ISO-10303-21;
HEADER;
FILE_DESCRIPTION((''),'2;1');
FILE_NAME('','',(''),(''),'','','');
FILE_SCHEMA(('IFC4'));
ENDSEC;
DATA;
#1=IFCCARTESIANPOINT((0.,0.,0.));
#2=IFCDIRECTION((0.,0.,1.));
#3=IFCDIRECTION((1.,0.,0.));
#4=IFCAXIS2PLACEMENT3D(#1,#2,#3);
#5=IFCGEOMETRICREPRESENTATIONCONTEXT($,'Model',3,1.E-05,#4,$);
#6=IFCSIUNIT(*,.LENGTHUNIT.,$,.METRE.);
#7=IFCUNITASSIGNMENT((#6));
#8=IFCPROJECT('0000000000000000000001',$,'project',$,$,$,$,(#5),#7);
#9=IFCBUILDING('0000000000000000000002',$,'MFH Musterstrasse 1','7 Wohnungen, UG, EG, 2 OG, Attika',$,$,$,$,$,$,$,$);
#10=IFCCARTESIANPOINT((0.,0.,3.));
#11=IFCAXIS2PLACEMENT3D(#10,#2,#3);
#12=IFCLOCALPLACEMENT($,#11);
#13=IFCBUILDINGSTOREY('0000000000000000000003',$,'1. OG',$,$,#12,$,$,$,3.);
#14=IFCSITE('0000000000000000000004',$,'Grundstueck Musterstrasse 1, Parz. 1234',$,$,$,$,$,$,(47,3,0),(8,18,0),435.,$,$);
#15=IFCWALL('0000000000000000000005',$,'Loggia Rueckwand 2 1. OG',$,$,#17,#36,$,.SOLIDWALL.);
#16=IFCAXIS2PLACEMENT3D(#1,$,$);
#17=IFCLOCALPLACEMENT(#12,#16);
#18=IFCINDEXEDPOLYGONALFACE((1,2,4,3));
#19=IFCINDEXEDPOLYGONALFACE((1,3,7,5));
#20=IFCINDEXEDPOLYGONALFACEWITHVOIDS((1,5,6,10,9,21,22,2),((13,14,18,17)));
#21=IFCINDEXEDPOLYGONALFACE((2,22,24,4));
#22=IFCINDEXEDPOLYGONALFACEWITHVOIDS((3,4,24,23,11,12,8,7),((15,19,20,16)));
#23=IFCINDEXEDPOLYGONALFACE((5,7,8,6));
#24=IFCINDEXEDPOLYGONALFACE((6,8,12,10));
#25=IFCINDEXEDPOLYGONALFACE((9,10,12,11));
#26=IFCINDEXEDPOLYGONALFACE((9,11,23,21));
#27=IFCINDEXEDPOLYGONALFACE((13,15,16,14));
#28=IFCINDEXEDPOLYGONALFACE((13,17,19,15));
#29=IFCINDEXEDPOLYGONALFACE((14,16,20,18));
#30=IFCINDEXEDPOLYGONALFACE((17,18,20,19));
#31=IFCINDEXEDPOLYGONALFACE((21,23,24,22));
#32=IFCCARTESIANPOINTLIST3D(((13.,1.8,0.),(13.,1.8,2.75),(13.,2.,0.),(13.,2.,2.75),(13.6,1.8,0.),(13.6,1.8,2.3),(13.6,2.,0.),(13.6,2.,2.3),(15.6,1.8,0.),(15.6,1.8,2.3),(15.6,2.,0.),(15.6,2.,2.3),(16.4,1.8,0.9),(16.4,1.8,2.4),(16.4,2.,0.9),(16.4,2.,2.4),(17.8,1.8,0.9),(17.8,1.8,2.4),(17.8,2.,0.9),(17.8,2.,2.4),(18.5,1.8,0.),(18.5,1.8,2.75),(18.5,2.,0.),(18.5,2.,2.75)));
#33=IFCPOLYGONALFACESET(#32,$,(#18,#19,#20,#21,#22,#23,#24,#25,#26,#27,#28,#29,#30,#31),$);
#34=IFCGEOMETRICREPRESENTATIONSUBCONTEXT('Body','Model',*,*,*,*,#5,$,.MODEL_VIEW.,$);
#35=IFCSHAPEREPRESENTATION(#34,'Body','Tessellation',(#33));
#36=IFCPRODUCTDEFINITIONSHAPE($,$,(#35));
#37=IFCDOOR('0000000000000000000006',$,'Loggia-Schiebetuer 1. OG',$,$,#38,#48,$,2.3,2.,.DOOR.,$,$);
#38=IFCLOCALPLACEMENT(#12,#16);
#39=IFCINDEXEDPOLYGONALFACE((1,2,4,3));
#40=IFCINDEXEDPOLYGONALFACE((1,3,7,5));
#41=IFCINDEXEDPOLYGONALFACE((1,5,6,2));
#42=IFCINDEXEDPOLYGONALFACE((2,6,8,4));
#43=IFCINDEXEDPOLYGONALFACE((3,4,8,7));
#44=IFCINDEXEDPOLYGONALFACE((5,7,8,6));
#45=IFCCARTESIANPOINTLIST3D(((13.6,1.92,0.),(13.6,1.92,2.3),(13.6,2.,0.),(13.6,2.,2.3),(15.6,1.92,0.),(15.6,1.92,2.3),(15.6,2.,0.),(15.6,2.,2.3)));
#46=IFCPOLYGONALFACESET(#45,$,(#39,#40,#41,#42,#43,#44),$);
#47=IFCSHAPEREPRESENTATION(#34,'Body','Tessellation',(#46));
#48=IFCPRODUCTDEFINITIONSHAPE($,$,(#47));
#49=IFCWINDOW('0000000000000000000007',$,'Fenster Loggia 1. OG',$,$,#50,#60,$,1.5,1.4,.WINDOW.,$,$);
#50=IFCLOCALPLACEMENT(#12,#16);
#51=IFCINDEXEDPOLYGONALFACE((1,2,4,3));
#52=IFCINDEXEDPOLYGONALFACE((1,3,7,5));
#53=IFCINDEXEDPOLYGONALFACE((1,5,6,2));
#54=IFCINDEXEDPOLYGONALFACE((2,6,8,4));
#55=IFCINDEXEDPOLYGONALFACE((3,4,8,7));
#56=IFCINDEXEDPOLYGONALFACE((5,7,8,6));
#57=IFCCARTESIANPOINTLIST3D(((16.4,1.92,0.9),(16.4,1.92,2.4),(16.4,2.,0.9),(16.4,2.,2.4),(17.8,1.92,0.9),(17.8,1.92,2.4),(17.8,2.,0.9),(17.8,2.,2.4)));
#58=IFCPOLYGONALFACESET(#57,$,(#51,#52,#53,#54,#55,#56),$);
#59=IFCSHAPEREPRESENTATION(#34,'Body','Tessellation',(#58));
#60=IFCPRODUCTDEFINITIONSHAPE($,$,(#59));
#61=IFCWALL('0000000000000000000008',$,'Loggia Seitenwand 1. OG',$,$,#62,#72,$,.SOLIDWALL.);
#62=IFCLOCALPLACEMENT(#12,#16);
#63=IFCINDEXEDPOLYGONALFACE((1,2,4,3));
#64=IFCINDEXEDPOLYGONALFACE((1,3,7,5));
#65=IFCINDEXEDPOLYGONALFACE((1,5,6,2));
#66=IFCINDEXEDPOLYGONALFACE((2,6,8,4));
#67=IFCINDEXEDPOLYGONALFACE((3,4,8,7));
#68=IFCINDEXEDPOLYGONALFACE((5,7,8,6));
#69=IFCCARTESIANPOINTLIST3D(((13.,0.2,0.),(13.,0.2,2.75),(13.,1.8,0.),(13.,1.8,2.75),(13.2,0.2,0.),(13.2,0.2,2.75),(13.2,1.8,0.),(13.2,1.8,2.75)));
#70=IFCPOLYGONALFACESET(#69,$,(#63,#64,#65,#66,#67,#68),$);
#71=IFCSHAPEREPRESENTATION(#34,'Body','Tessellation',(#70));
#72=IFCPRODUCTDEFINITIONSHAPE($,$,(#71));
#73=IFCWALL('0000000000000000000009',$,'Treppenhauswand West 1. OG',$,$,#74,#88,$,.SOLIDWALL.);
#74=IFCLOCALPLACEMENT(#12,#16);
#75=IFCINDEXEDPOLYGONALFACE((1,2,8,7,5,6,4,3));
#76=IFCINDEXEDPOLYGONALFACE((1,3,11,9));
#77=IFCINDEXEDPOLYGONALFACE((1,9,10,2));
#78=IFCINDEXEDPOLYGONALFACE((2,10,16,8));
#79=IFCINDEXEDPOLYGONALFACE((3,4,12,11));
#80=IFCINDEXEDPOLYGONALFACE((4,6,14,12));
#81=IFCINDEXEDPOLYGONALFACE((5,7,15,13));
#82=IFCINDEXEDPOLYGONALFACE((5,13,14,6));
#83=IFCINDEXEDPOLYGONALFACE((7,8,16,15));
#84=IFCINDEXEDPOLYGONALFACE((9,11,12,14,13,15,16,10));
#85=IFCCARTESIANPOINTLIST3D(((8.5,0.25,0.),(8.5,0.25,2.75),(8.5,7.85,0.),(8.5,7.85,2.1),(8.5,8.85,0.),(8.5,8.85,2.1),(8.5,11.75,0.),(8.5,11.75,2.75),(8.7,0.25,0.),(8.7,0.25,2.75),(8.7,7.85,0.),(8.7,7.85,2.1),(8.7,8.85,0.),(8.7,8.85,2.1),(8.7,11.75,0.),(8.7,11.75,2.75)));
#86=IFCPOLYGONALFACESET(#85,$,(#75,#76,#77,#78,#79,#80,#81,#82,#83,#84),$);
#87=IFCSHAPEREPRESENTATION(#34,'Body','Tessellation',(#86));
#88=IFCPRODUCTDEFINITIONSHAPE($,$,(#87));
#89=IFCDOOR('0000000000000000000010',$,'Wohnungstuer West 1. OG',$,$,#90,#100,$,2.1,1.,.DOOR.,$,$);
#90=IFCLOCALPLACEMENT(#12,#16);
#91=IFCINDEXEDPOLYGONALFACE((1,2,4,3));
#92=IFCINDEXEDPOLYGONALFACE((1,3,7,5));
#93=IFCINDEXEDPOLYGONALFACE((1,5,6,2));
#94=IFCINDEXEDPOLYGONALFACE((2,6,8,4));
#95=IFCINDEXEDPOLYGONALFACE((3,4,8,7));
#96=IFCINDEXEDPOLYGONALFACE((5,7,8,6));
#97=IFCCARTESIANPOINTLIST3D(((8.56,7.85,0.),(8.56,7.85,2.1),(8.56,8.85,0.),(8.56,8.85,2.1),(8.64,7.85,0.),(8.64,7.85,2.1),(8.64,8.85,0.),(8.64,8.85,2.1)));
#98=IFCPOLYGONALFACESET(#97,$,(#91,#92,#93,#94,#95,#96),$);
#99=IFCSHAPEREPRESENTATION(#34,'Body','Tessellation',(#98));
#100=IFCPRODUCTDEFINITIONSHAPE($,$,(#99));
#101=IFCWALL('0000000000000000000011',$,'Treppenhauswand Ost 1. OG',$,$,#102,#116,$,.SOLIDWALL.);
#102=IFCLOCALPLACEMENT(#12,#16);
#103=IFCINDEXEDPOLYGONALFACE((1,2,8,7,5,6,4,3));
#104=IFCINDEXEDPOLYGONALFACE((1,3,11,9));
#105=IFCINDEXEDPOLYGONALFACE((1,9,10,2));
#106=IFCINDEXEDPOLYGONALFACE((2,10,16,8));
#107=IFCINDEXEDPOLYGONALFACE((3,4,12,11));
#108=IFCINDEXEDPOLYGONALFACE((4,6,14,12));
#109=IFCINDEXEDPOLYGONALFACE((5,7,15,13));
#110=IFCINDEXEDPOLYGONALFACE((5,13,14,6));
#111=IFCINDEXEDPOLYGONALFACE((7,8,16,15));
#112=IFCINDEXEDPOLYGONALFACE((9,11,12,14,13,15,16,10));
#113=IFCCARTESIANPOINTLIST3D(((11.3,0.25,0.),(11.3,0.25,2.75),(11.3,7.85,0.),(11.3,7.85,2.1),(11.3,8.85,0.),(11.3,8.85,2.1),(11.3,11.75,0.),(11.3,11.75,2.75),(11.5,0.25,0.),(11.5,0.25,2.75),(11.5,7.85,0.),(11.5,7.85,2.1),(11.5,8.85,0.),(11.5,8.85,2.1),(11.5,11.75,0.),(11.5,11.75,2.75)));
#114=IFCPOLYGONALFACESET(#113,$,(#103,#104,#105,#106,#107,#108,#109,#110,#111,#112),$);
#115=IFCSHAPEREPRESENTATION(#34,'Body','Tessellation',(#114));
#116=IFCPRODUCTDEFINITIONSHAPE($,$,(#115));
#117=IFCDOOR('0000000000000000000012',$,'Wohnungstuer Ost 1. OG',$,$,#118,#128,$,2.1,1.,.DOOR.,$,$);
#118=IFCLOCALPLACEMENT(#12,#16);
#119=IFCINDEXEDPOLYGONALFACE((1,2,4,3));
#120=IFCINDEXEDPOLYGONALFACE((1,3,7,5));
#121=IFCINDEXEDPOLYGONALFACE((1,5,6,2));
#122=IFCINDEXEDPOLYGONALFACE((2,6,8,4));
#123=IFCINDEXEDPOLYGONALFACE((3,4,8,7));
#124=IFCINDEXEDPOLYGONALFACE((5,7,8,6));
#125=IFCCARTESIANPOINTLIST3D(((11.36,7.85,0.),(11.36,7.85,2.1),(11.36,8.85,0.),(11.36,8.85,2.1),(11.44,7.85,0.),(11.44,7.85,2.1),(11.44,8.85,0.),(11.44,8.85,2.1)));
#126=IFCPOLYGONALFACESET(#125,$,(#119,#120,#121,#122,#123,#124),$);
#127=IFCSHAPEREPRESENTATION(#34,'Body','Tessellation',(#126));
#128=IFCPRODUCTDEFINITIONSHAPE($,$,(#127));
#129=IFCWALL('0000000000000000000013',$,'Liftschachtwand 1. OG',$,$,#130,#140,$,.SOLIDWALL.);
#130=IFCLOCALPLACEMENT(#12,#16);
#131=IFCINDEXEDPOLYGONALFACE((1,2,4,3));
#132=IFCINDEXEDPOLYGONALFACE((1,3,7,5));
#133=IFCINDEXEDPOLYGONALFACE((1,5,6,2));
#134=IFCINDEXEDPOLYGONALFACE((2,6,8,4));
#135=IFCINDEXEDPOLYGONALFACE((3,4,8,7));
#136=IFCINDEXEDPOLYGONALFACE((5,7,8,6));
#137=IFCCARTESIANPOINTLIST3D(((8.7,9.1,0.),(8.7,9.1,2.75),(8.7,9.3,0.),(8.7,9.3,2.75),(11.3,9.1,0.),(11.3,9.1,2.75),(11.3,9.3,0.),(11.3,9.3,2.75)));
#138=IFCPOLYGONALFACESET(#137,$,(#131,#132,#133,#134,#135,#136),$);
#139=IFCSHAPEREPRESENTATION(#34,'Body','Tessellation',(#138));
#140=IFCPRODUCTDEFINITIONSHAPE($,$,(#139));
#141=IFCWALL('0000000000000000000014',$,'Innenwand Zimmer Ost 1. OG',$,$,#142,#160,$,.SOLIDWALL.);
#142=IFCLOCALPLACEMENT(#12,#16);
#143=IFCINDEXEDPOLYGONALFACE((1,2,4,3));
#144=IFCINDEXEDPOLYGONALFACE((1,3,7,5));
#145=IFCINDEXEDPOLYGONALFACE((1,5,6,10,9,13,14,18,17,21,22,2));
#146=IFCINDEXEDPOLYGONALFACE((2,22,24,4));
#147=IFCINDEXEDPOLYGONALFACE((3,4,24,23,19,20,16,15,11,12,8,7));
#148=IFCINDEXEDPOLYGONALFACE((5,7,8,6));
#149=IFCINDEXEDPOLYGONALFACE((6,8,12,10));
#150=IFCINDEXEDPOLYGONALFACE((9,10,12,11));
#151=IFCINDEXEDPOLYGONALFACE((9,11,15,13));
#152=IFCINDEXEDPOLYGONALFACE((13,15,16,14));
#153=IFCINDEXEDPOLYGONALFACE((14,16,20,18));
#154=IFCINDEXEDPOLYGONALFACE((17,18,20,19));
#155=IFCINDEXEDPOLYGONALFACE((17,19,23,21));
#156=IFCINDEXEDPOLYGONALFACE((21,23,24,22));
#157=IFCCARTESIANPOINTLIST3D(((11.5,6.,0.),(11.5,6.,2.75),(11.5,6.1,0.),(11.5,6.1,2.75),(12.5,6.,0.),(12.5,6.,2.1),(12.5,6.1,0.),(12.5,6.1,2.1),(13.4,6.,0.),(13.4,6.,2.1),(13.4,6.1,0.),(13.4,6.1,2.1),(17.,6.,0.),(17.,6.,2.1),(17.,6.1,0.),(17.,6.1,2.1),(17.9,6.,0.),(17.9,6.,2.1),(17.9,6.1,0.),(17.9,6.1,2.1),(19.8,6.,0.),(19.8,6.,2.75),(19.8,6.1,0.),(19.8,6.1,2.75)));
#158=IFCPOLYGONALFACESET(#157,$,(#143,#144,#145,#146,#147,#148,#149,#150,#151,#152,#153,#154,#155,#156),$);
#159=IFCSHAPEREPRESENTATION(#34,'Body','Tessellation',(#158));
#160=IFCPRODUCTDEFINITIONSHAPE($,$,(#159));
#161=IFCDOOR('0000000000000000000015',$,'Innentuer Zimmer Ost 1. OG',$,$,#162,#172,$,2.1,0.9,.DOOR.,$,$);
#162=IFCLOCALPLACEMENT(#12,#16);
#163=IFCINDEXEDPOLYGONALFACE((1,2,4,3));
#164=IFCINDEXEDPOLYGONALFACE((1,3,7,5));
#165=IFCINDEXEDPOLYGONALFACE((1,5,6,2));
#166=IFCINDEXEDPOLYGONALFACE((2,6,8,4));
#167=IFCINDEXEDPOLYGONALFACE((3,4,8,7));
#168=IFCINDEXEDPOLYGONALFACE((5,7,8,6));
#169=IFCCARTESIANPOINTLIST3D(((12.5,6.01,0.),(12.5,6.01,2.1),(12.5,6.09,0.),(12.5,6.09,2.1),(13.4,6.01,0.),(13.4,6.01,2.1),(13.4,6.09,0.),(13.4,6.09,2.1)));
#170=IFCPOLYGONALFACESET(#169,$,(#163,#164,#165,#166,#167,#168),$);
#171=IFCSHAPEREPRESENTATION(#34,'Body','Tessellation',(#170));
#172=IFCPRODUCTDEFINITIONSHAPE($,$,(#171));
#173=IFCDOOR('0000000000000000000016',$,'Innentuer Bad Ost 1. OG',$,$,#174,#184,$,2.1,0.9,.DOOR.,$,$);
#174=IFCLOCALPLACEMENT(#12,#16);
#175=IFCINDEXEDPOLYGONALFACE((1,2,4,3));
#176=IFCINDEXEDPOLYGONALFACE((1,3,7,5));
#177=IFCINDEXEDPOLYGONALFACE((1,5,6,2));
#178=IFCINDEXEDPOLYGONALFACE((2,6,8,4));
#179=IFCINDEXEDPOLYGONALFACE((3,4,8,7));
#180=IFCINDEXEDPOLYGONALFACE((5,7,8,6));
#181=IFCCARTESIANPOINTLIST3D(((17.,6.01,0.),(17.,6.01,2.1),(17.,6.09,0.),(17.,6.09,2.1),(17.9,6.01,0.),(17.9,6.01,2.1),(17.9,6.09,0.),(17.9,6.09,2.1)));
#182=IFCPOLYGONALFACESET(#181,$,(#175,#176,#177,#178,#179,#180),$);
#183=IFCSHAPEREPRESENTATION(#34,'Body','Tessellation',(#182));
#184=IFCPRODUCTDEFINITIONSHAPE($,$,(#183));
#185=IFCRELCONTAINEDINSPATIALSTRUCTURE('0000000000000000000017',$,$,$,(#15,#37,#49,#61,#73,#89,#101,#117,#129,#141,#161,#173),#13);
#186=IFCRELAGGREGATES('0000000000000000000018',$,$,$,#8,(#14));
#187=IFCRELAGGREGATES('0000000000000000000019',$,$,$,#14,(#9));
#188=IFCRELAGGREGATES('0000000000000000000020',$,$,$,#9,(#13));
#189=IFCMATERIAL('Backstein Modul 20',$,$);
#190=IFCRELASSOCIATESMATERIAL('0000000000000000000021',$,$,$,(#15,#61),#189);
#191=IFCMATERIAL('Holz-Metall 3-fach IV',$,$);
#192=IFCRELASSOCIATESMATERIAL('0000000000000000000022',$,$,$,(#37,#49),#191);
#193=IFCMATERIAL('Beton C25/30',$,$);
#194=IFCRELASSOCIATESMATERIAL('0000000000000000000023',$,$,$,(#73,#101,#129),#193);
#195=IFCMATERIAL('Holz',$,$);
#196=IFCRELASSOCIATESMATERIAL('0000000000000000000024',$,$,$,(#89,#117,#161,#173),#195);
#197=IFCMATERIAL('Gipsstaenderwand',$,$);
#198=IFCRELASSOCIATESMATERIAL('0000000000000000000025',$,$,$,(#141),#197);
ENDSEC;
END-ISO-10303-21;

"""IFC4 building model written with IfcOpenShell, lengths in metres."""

from ifc_helpers import new_model, si_unit, frame, frame_2d, origin_with_axes, place, context, subcontext, project, spatial, rectangle, extrude, material, element, fill, save


model = new_model("IFC4")

# Units and contexts
model_context = context("Model", 3, precision=1e-05, world=origin_with_axes())
body_context = subcontext(model_context, "Body", "Model", "MODEL_VIEW")
ifc_project = project(units=[si_unit("LENGTHUNIT", "METRE")], contexts=[model_context])

# Site, building, storey
site = spatial("IfcSite", under=ifc_project, Name="Grundstueck Musterstrasse 1, Parz. 1234", RefLatitude=(47, 3, 0), RefLongitude=(8, 18, 0), RefElevation=435.0)
building = spatial("IfcBuilding", under=site, Name="MFH Musterstrasse 1", Description="7 Wohnungen, UG, EG, 2 OG, Attika")
storey_placement = place(None, frame((0.0, 0.0, 3.0), z_axis=(0.0, 0.0, 1.0), x_axis=(1.0, 0.0, 0.0)))
storey = spatial("IfcBuildingStorey", under=building, at=storey_placement, Name="1. OG", Elevation=3.0)

# Wall, openings, door, window
ifc_material_1 = material(Name="Backstein Modul 20")
wall_1_placement = place(storey_placement, frame((13.0, 1.8, 0.0), z_axis=(0.0, 0.0, 1.0), x_axis=(1.0, 0.0, 0.0)))
wall_1 = element("IfcWall", 1, at=wall_1_placement, inside=storey, material=ifc_material_1, Name="Loggia Rueckwand 2 1. OG", PredefinedType="SOLIDWALL", context=body_context, shape_type="SweptSolid", body=[
    extrude(rectangle(XDim=5.5, YDim=0.2, at=frame_2d((2.75, 0.1))), origin_with_axes(), (0.0, 0.0, 1.0), 2.75),
])
opening_1_placement = place(wall_1_placement, frame((0.6, -0.21, 0.0), z_axis=(0.0, 0.0, 1.0), x_axis=(1.0, 0.0, 0.0)))
opening_1 = element("IfcOpeningElement", 2, at=opening_1_placement, cuts=wall_1, context=body_context, shape_type="SweptSolid", body=[
    extrude(rectangle(XDim=2.0, YDim=0.42, at=frame_2d((1.0, 0.21))), origin_with_axes(), (0.0, 0.0, 1.0), 2.3),
])
opening_2_placement = place(wall_1_placement, frame((3.4, -0.21, 0.9), z_axis=(0.0, 0.0, 1.0), x_axis=(1.0, 0.0, 0.0)))
opening_2 = element("IfcOpeningElement", 3, at=opening_2_placement, cuts=wall_1, context=body_context, shape_type="SweptSolid", body=[
    extrude(rectangle(XDim=1.4, YDim=0.42, at=frame_2d((0.7, 0.21))), origin_with_axes(), (0.0, 0.0, 1.0), 1.5),
])
ifc_material_2 = material(Name="Holz-Metall 3-fach IV")
door_1_placement = place(storey_placement, frame((13.6, 1.92, 0.0), z_axis=(0.0, 0.0, 1.0), x_axis=(1.0, 0.0, 0.0)))
door_1 = element("IfcDoor", 4, at=door_1_placement, inside=storey, material=ifc_material_2, Name="Loggia-Schiebetuer 1. OG", OverallHeight=2.3, OverallWidth=2.0, PredefinedType="DOOR", context=body_context, shape_type="SweptSolid", body=[
    extrude(rectangle(XDim=2.0, YDim=0.08, at=frame_2d((1.0, 0.04))), origin_with_axes(), (0.0, 0.0, 1.0), 2.3),
])
fill(opening_1, door_1)
window_placement = place(storey_placement, frame((16.4, 1.92, 0.9), z_axis=(0.0, 0.0, 1.0), x_axis=(1.0, 0.0, 0.0)))
window = element("IfcWindow", 5, at=window_placement, inside=storey, material=ifc_material_2, Name="Fenster Loggia 1. OG", OverallHeight=1.5, OverallWidth=1.4, PredefinedType="WINDOW", context=body_context, shape_type="SweptSolid", body=[
    extrude(rectangle(XDim=1.4, YDim=0.08, at=frame_2d((0.7, 0.04))), origin_with_axes(), (0.0, 0.0, 1.0), 1.5),
])
fill(opening_2, window)

# Wall
wall_2_placement = place(storey_placement, frame((13.0, 0.2, 0.0), z_axis=(0.0, 0.0, 1.0), x_axis=(1.0, 0.0, 0.0)))
element("IfcWall", 6, at=wall_2_placement, inside=storey, material=ifc_material_1, Name="Loggia Seitenwand 1. OG", PredefinedType="SOLIDWALL", context=body_context, shape_type="SweptSolid", body=[
    extrude(rectangle(XDim=0.2, YDim=1.6, at=frame_2d((0.1, 0.8))), origin_with_axes(), (0.0, 0.0, 1.0), 2.75),
])

# Walls, openings, doors
ifc_material_3 = material(Name="Beton C25/30")
wall_3_placement = place(storey_placement, frame((8.5, 0.25, 0.0), z_axis=(0.0, 0.0, 1.0), x_axis=(1.0, 0.0, 0.0)))
wall_3 = element("IfcWall", 7, at=wall_3_placement, inside=storey, material=ifc_material_3, Name="Treppenhauswand West 1. OG", PredefinedType="SOLIDWALL", context=body_context, shape_type="SweptSolid", body=[
    extrude(rectangle(XDim=0.2, YDim=11.5, at=frame_2d((0.1, 5.75))), origin_with_axes(), (0.0, 0.0, 1.0), 2.75),
])
opening_3_placement = place(wall_3_placement, frame((-0.01, 7.6, 0.0), z_axis=(0.0, 0.0, 1.0), x_axis=(1.0, 0.0, 0.0)))
opening_3 = element("IfcOpeningElement", 8, at=opening_3_placement, cuts=wall_3, context=body_context, shape_type="SweptSolid", body=[
    extrude(rectangle(XDim=0.22, YDim=1.0, at=frame_2d((0.11, 0.5))), origin_with_axes(), (0.0, 0.0, 1.0), 2.1),
])
ifc_material_4 = material(Name="Holz")
door_2_placement = place(storey_placement, frame((8.56, 7.85, 0.0), z_axis=(0.0, 0.0, 1.0), x_axis=(1.0, 0.0, 0.0)))
door_2 = element("IfcDoor", 9, at=door_2_placement, inside=storey, material=ifc_material_4, Name="Wohnungstuer West 1. OG", OverallHeight=2.1, OverallWidth=1.0, PredefinedType="DOOR", context=body_context, shape_type="SweptSolid", body=[
    extrude(rectangle(XDim=0.08, YDim=1.0, at=frame_2d((0.04, 0.5))), origin_with_axes(), (0.0, 0.0, 1.0), 2.1),
])
fill(opening_3, door_2)
wall_4_placement = place(storey_placement, frame((11.3, 0.25, 0.0), z_axis=(0.0, 0.0, 1.0), x_axis=(1.0, 0.0, 0.0)))
wall_4 = element("IfcWall", 10, at=wall_4_placement, inside=storey, material=ifc_material_3, Name="Treppenhauswand Ost 1. OG", PredefinedType="SOLIDWALL", context=body_context, shape_type="SweptSolid", body=[
    extrude(rectangle(XDim=0.2, YDim=11.5, at=frame_2d((0.1, 5.75))), origin_with_axes(), (0.0, 0.0, 1.0), 2.75),
])
opening_4_placement = place(wall_4_placement, frame((-0.01, 7.6, 0.0), z_axis=(0.0, 0.0, 1.0), x_axis=(1.0, 0.0, 0.0)))
opening_4 = element("IfcOpeningElement", 11, at=opening_4_placement, cuts=wall_4, context=body_context, shape_type="SweptSolid", body=[
    extrude(rectangle(XDim=0.22, YDim=1.0, at=frame_2d((0.11, 0.5))), origin_with_axes(), (0.0, 0.0, 1.0), 2.1),
])
door_3_placement = place(storey_placement, frame((11.36, 7.85, 0.0), z_axis=(0.0, 0.0, 1.0), x_axis=(1.0, 0.0, 0.0)))
door_3 = element("IfcDoor", 12, at=door_3_placement, inside=storey, material=ifc_material_4, Name="Wohnungstuer Ost 1. OG", OverallHeight=2.1, OverallWidth=1.0, PredefinedType="DOOR", context=body_context, shape_type="SweptSolid", body=[
    extrude(rectangle(XDim=0.08, YDim=1.0, at=frame_2d((0.04, 0.5))), origin_with_axes(), (0.0, 0.0, 1.0), 2.1),
])
fill(opening_4, door_3)

# Wall
wall_5_placement = place(storey_placement, frame((8.7, 9.1, 0.0), z_axis=(0.0, 0.0, 1.0), x_axis=(1.0, 0.0, 0.0)))
element("IfcWall", 13, at=wall_5_placement, inside=storey, material=ifc_material_3, Name="Liftschachtwand 1. OG", PredefinedType="SOLIDWALL", context=body_context, shape_type="SweptSolid", body=[
    extrude(rectangle(XDim=2.6, YDim=0.2, at=frame_2d((1.3, 0.1))), origin_with_axes(), (0.0, 0.0, 1.0), 2.75),
])

# Wall, openings, doors
ifc_material_5 = material(Name="Gipsstaenderwand")
wall_6_placement = place(storey_placement, frame((11.5, 6.0, 0.0), z_axis=(0.0, 0.0, 1.0), x_axis=(1.0, 0.0, 0.0)))
wall_6 = element("IfcWall", 14, at=wall_6_placement, inside=storey, material=ifc_material_5, Name="Innenwand Zimmer Ost 1. OG", PredefinedType="SOLIDWALL", context=body_context, shape_type="SweptSolid", body=[
    extrude(rectangle(XDim=8.3, YDim=0.1, at=frame_2d((4.15, 0.05))), origin_with_axes(), (0.0, 0.0, 1.0), 2.75),
])
opening_5_placement = place(wall_6_placement, frame((1.0, -0.01, 0.0), z_axis=(0.0, 0.0, 1.0), x_axis=(1.0, 0.0, 0.0)))
opening_5 = element("IfcOpeningElement", 15, at=opening_5_placement, cuts=wall_6, context=body_context, shape_type="SweptSolid", body=[
    extrude(rectangle(XDim=0.9, YDim=0.12, at=frame_2d((0.45, 0.06))), origin_with_axes(), (0.0, 0.0, 1.0), 2.1),
])
opening_6_placement = place(wall_6_placement, frame((5.5, -0.01, 0.0), z_axis=(0.0, 0.0, 1.0), x_axis=(1.0, 0.0, 0.0)))
opening_6 = element("IfcOpeningElement", 16, at=opening_6_placement, cuts=wall_6, context=body_context, shape_type="SweptSolid", body=[
    extrude(rectangle(XDim=0.9, YDim=0.12, at=frame_2d((0.45, 0.06))), origin_with_axes(), (0.0, 0.0, 1.0), 2.1),
])
door_4_placement = place(storey_placement, frame((12.5, 6.01, 0.0), z_axis=(0.0, 0.0, 1.0), x_axis=(1.0, 0.0, 0.0)))
door_4 = element("IfcDoor", 17, at=door_4_placement, inside=storey, material=ifc_material_4, Name="Innentuer Zimmer Ost 1. OG", OverallHeight=2.1, OverallWidth=0.9, PredefinedType="DOOR", context=body_context, shape_type="SweptSolid", body=[
    extrude(rectangle(XDim=0.9, YDim=0.08, at=frame_2d((0.45, 0.04))), origin_with_axes(), (0.0, 0.0, 1.0), 2.1),
])
fill(opening_5, door_4)
door_5_placement = place(storey_placement, frame((17.0, 6.01, 0.0), z_axis=(0.0, 0.0, 1.0), x_axis=(1.0, 0.0, 0.0)))
door_5 = element("IfcDoor", 18, at=door_5_placement, inside=storey, material=ifc_material_4, Name="Innentuer Bad Ost 1. OG", OverallHeight=2.1, OverallWidth=0.9, PredefinedType="DOOR", context=body_context, shape_type="SweptSolid", body=[
    extrude(rectangle(XDim=0.9, YDim=0.08, at=frame_2d((0.45, 0.04))), origin_with_axes(), (0.0, 0.0, 1.0), 2.1),
])
fill(opening_6, door_5)

save(model, "model.ifc")
